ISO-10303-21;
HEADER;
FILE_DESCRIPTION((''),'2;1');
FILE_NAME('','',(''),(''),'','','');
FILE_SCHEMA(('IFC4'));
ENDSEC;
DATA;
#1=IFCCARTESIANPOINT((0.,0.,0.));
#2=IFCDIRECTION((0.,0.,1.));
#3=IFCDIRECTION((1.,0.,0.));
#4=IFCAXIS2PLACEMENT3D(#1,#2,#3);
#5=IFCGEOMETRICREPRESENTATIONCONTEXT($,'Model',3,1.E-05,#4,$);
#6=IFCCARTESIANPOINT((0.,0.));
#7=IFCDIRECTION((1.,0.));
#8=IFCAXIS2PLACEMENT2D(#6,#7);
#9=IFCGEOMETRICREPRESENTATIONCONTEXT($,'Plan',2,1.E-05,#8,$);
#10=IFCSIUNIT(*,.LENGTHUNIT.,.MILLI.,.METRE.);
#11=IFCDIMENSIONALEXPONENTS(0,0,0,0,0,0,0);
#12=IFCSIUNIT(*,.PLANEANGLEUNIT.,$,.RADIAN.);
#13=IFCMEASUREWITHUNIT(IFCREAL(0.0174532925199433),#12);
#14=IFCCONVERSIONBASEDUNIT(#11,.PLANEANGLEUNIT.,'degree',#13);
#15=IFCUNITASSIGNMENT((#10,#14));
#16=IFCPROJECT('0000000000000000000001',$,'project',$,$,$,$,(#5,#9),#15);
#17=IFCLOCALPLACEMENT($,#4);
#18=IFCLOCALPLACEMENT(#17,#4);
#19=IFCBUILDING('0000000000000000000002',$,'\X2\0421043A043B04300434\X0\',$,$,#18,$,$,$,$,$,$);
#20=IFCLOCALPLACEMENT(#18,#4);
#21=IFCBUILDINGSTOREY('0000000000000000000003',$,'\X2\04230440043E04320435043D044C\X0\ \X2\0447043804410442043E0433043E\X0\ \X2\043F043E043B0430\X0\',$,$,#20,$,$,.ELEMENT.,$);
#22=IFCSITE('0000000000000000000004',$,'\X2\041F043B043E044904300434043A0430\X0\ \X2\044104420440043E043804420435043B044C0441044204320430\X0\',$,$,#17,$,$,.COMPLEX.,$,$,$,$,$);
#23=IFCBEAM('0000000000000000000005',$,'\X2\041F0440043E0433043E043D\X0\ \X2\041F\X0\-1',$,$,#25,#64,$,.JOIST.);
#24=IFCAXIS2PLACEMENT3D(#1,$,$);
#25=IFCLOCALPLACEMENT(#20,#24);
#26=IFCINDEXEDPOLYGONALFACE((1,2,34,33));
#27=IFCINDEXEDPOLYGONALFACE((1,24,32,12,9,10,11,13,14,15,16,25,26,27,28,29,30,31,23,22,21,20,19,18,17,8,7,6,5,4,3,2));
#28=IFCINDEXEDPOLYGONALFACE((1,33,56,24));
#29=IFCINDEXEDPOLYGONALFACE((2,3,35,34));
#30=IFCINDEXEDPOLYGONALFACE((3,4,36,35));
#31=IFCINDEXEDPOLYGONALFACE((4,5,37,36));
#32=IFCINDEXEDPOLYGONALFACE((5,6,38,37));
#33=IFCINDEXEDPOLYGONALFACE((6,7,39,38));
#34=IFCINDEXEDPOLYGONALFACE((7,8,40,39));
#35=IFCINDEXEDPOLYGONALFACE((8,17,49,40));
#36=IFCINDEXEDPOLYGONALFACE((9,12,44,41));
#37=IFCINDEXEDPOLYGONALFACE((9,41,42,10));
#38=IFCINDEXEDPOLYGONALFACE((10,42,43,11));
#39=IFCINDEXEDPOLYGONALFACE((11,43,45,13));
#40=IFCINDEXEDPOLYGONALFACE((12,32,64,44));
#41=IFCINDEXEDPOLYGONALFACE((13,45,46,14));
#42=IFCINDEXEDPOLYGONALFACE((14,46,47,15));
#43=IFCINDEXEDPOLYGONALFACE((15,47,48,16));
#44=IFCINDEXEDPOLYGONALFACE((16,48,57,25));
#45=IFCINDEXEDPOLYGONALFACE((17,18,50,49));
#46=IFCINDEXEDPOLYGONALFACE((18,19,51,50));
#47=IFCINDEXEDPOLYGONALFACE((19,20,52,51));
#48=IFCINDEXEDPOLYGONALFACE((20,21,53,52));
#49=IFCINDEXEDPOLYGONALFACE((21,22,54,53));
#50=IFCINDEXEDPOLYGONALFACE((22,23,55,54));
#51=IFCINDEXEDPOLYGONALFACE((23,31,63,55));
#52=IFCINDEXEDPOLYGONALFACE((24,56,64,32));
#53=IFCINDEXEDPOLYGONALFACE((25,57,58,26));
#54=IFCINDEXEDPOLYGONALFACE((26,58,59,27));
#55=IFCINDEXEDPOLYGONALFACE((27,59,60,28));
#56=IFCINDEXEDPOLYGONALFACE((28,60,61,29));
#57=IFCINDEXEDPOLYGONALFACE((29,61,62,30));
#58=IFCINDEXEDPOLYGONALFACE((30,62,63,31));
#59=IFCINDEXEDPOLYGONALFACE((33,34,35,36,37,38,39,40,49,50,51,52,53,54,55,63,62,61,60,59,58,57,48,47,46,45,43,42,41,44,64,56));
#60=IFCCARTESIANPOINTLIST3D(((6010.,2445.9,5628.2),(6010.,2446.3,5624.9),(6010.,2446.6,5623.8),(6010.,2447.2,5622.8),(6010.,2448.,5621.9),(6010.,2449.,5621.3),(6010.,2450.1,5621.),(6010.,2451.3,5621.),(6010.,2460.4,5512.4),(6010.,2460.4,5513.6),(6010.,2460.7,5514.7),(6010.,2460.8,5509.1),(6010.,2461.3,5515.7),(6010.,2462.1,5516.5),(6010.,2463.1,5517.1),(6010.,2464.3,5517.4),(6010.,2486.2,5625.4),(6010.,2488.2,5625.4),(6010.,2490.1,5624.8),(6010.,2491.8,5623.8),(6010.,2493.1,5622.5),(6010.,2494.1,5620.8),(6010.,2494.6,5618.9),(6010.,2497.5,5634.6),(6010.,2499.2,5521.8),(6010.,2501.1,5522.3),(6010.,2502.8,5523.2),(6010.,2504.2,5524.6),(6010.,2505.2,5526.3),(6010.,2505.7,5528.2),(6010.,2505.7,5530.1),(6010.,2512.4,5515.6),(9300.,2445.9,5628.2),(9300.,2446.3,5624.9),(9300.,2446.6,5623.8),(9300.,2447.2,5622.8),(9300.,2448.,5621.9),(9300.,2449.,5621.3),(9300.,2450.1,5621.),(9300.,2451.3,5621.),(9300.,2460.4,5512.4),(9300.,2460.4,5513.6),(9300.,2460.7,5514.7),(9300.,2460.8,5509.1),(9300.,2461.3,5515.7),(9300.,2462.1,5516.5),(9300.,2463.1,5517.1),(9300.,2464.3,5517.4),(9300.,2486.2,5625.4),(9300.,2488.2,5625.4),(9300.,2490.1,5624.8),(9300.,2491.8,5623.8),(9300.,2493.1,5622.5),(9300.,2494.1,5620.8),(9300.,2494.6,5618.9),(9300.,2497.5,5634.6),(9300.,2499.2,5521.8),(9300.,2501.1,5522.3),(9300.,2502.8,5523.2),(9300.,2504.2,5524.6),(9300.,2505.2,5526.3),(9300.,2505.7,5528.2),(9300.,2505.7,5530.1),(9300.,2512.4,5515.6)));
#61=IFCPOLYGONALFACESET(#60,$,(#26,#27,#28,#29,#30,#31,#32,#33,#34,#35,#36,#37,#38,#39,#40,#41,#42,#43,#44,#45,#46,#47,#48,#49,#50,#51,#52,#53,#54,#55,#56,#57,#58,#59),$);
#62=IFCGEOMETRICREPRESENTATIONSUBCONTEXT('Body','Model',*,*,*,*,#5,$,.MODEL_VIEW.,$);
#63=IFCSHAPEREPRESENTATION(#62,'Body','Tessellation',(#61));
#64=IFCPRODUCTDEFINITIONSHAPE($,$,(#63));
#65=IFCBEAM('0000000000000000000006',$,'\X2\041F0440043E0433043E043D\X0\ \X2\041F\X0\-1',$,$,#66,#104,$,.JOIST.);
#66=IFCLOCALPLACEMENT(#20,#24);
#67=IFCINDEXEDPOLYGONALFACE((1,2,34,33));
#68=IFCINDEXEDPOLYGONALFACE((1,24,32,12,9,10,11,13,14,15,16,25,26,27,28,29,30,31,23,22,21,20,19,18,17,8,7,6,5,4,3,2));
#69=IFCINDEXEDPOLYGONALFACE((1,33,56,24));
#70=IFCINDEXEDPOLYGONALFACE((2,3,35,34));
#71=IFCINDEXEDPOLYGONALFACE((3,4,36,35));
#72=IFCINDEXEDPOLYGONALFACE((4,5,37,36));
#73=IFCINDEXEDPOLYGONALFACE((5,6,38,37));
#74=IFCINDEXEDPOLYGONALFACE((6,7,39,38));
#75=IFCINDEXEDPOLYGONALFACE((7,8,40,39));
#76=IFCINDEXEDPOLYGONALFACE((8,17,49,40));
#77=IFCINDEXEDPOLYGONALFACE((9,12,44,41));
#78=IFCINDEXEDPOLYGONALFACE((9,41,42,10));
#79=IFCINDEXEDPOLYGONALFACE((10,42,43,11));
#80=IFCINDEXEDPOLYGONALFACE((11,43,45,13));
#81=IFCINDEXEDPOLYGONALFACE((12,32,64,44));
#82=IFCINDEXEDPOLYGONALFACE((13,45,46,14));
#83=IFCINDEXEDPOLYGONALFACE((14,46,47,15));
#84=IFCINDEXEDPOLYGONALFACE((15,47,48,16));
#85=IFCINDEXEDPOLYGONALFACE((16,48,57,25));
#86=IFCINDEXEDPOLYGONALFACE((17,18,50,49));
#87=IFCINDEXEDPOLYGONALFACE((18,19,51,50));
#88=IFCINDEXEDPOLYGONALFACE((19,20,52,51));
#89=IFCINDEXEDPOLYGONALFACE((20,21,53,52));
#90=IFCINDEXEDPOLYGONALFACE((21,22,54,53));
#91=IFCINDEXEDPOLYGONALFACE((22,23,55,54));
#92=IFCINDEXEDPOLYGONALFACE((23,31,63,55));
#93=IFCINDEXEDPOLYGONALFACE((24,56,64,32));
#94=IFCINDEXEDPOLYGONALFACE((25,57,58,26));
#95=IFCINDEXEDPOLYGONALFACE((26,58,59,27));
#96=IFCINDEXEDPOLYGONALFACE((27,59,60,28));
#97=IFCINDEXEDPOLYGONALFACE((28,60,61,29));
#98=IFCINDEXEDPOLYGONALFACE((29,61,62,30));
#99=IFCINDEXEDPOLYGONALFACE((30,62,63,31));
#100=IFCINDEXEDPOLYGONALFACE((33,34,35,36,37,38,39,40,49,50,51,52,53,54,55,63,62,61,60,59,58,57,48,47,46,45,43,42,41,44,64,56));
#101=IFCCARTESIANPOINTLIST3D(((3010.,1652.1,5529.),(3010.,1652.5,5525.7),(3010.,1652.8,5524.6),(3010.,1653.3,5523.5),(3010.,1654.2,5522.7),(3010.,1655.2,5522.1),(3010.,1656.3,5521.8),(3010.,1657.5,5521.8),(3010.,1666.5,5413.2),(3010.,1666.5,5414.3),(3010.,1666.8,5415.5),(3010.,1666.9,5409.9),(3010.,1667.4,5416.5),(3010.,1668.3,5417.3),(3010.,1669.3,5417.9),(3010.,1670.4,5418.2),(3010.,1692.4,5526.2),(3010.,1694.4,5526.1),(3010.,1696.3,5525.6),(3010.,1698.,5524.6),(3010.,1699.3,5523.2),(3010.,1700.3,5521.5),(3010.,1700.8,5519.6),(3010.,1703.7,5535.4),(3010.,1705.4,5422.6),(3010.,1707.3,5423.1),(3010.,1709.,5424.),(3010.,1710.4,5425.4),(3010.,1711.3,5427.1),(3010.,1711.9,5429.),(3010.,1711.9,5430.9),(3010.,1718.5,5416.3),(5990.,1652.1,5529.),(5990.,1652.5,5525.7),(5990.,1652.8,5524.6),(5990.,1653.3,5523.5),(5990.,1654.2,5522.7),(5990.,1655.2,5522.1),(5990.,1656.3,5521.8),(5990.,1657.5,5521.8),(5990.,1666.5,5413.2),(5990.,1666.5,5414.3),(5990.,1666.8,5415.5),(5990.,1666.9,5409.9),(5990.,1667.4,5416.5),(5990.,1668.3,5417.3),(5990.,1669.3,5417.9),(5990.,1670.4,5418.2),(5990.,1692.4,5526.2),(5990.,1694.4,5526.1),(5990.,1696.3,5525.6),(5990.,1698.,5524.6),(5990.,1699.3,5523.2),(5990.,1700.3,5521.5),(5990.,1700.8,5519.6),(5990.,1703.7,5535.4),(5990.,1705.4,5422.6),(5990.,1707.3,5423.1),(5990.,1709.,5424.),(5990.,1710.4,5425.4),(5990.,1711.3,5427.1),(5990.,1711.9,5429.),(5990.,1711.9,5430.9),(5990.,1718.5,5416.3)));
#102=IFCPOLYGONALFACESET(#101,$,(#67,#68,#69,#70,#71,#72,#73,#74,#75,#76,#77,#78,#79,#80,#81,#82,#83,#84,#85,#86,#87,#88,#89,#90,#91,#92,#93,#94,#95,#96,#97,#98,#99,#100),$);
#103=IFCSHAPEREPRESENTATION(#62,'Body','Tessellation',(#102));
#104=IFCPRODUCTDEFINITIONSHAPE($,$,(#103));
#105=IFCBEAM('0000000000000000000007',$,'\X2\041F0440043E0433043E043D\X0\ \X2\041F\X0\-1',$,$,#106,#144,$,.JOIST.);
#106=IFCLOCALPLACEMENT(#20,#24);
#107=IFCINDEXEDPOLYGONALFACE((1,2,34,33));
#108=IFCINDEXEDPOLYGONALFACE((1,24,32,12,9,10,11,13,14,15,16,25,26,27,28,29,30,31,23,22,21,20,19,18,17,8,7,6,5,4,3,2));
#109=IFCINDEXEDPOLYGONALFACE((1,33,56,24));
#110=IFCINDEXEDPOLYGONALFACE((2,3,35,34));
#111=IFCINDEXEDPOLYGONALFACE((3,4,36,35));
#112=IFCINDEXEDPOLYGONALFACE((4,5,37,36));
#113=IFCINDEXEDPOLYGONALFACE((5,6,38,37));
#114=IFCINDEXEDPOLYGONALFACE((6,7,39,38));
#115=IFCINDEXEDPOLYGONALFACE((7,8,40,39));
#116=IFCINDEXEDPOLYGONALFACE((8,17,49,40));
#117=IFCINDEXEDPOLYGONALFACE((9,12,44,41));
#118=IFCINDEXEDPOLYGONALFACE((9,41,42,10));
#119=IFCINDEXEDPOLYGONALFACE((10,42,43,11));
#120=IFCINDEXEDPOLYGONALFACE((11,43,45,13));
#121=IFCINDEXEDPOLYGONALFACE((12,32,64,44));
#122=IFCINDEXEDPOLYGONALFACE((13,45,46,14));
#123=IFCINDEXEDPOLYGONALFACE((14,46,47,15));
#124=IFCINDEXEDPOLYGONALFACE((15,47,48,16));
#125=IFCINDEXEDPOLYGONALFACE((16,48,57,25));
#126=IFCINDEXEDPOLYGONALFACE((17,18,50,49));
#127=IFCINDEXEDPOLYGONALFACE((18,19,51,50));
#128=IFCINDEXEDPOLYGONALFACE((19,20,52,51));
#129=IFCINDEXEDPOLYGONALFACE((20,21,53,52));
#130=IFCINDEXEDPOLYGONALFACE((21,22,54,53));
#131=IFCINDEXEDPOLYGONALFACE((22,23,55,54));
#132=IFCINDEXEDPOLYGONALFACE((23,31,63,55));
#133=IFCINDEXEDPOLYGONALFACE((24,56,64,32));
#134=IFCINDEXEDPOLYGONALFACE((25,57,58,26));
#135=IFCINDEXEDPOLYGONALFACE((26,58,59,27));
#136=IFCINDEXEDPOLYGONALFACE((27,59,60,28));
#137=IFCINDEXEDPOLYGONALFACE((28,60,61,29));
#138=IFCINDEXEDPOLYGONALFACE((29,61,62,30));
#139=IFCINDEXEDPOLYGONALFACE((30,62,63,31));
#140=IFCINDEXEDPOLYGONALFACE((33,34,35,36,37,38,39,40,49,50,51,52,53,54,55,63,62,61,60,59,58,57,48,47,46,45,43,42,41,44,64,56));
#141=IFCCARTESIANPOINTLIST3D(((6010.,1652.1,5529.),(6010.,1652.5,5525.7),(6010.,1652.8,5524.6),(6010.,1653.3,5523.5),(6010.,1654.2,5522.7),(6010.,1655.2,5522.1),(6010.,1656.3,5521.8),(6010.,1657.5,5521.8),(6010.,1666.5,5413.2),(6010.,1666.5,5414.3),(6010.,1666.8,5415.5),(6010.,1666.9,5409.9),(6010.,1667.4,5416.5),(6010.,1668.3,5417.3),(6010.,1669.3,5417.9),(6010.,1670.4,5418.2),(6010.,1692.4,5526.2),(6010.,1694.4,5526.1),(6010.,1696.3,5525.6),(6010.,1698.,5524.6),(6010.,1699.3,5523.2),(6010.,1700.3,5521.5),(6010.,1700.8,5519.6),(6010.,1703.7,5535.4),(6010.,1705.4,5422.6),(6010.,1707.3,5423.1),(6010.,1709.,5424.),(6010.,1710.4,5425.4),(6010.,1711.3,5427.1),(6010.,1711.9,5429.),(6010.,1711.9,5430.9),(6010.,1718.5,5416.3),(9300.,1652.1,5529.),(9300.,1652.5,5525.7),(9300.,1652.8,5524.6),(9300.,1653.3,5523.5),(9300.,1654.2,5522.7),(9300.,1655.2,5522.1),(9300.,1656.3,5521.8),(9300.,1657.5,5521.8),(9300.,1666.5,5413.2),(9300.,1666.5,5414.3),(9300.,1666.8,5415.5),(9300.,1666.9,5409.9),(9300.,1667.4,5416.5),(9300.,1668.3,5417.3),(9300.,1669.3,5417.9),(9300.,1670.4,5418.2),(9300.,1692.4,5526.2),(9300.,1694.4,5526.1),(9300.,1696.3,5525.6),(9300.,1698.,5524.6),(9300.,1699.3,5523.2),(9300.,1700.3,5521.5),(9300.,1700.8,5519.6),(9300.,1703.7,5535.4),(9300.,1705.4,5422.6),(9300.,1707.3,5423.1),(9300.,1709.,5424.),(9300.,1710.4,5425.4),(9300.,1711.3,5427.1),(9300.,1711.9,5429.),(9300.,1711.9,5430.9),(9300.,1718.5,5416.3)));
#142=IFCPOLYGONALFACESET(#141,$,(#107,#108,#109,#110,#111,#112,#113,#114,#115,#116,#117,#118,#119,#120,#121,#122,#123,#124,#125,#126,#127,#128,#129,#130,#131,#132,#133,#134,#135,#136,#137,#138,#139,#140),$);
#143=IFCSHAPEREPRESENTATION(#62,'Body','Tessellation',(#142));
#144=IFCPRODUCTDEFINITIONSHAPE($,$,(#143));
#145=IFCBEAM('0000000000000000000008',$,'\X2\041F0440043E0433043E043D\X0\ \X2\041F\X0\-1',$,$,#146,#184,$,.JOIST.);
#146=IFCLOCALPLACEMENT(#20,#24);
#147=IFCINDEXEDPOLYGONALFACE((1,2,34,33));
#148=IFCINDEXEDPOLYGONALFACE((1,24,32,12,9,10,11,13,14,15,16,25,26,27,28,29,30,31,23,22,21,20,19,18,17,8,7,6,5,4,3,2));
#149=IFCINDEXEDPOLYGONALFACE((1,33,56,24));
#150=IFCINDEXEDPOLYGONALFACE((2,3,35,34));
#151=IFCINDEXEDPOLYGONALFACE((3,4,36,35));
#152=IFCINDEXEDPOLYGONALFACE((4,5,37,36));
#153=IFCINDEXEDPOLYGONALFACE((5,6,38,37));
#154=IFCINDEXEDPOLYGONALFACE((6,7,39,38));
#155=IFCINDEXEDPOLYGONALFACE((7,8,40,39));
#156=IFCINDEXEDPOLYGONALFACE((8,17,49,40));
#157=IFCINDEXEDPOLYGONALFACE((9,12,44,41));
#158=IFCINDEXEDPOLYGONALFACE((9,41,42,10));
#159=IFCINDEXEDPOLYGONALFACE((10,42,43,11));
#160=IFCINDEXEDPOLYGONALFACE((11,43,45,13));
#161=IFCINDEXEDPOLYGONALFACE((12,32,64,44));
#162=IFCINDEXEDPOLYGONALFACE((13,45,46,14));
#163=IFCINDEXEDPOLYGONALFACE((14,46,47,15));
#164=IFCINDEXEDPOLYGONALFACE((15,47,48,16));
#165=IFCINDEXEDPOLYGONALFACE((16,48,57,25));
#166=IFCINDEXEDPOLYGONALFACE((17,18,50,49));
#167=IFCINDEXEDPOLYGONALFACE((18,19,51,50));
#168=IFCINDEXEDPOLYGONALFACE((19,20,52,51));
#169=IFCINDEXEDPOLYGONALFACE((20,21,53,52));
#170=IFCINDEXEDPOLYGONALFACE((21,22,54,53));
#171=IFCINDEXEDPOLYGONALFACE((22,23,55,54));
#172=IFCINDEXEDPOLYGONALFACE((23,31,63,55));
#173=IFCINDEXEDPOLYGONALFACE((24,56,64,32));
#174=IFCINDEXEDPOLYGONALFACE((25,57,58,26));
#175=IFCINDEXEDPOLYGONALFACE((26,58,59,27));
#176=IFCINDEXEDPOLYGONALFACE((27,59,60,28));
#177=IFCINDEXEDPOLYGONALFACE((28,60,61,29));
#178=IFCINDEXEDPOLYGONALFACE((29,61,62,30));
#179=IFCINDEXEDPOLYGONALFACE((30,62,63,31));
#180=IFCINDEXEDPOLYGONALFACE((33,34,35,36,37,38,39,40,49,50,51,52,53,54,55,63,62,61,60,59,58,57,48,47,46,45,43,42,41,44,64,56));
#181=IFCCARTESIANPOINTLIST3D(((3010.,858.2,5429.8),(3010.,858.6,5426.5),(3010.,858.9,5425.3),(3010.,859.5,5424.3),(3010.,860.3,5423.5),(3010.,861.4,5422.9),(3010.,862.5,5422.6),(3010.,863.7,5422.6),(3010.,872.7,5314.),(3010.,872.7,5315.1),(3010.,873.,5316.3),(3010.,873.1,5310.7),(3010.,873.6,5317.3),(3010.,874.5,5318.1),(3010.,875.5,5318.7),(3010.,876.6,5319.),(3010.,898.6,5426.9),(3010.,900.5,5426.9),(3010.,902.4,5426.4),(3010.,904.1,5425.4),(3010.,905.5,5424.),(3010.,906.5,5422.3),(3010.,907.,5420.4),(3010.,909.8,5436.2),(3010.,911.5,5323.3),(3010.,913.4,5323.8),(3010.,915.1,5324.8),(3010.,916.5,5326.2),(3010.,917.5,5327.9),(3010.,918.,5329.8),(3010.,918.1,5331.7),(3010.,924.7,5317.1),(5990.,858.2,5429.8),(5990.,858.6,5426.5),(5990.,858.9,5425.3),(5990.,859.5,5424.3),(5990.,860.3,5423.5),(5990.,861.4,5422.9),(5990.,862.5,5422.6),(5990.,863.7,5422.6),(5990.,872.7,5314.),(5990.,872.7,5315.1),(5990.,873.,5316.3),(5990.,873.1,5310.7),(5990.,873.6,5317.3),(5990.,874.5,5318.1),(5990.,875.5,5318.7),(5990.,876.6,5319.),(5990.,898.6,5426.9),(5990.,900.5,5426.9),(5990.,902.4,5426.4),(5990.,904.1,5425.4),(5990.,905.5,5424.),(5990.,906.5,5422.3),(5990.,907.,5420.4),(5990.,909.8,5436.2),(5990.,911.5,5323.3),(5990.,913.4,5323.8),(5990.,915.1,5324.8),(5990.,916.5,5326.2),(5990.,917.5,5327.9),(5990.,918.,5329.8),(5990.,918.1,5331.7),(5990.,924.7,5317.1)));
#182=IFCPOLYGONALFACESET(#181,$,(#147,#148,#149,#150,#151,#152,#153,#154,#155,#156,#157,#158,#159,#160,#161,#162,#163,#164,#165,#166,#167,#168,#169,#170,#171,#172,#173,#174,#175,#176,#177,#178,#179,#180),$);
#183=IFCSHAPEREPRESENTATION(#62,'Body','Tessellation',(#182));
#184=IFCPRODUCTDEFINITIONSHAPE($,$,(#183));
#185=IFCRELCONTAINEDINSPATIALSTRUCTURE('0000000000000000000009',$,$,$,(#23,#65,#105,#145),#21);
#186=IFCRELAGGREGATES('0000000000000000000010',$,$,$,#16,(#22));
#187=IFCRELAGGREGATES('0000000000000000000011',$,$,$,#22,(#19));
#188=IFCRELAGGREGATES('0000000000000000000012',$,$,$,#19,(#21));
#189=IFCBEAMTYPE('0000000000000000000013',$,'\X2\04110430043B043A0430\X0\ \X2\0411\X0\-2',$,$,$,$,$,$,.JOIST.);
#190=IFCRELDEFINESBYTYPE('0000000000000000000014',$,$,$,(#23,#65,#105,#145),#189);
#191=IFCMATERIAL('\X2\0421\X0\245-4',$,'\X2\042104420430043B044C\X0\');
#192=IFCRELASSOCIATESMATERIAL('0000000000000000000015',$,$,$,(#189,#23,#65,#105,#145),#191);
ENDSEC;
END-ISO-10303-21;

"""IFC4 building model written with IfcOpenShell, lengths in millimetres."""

from ifc_helpers import new_model, entity, si_unit, converted_unit, frame, origin_with_axes, origin_2d_with_axis, place, context, subcontext, project, spatial, u_section, extrude, material, material_profile, profile_set, profile_usage, type_object, element, save


model = new_model("IFC4")

# Units and contexts
model_context = context("Model", 3, precision=1e-05, world=origin_with_axes())
plan_context = context("Plan", 2, precision=1e-05, world=origin_2d_with_axis())
body_context = subcontext(model_context, "Body", "Model", "MODEL_VIEW")
ifc_project = project(units=[si_unit("LENGTHUNIT", "METRE", prefix="MILLI"), converted_unit("PLANEANGLEUNIT", "degree", entity("IfcReal", 0.0174532925199433), si_unit("PLANEANGLEUNIT", "RADIAN"), dimensions=[0, 0, 0, 0, 0, 0, 0])], contexts=[model_context, plan_context])

# Site, building, storey
site_placement = place(None, origin_with_axes())
site = spatial("IfcSite", under=ifc_project, at=site_placement, Name="Площадка строительства", CompositionType="COMPLEX")
building_placement = place(site_placement, origin_with_axes())
building = spatial("IfcBuilding", under=site, at=building_placement, Name="Склад")
storey_placement = place(building_placement, origin_with_axes())
storey = spatial("IfcBuildingStorey", under=building, at=storey_placement, Name="Уровень чистого пола", CompositionType="ELEMENT")

# Beams
ifc_material_1 = material(Name="С245-4", Category="Сталь")
ifc_material_profile_1 = material_profile(ifc_material_1, u_section(Depth=120.0, FlangeWidth=52.0, WebThickness=4.8, FlangeThickness=7.8, FilletRadius=7.5, EdgeRadius=4.5, FlangeSlope=0.0))
ifc_profile_set_1 = profile_set([ifc_material_profile_1], Name="U12P_S245-4")
beam_type_1 = type_object("IfcBeamType", Name="Балка Б-2", PredefinedType="JOIST", material=ifc_profile_set_1)
ifc_profile_usage_1 = profile_usage(ifc_profile_set_1, cardinal=3)
beam_1_placement = place(storey_placement, frame((9300.0, 2512.4, 5515.6), z_axis=(-1.0, 0.0, 0.0), x_axis=(0.0, -0.99228, -0.12402)))
element("IfcBeam", 1, at=beam_1_placement, inside=storey, type_object=beam_type_1, material=ifc_profile_usage_1, Name="Прогон П-1", PredefinedType="JOIST", context=body_context, shape_type="SweptSolid", body=[
    extrude(u_section(Depth=120.0, FlangeWidth=52.0, WebThickness=4.8, FlangeThickness=7.8, FilletRadius=7.5, EdgeRadius=4.5, FlangeSlope=0.0), frame((26.0, 60.0, 0.0), z_axis=(0.0, 0.0, 1.0), x_axis=(1.0, 0.0, 0.0)), (0.0, 0.0, 1.0), 3290.0),
])
ifc_profile_usage_2 = profile_usage(ifc_profile_set_1, cardinal=3)
beam_2_placement = place(storey_placement, frame((5990.0, 1718.5, 5416.3), z_axis=(-1.0, 0.0, 0.0), x_axis=(0.0, -0.99228, -0.12402)))
element("IfcBeam", 2, at=beam_2_placement, inside=storey, type_object=beam_type_1, material=ifc_profile_usage_2, Name="Прогон П-1", PredefinedType="JOIST", context=body_context, shape_type="SweptSolid", body=[
    extrude(u_section(Depth=120.0, FlangeWidth=52.0, WebThickness=4.8, FlangeThickness=7.8, FilletRadius=7.5, EdgeRadius=4.5, FlangeSlope=0.0), frame((26.0, 60.0, 0.0), z_axis=(0.0, 0.0, 1.0), x_axis=(1.0, 0.0, 0.0)), (0.0, 0.0, 1.0), 2980.0),
])
ifc_profile_usage_3 = profile_usage(ifc_profile_set_1, cardinal=3)
beam_3_placement = place(storey_placement, frame((9300.0, 1718.5, 5416.3), z_axis=(-1.0, 0.0, 0.0), x_axis=(0.0, -0.99228, -0.12402)))
element("IfcBeam", 3, at=beam_3_placement, inside=storey, type_object=beam_type_1, material=ifc_profile_usage_3, Name="Прогон П-1", PredefinedType="JOIST", context=body_context, shape_type="SweptSolid", body=[
    extrude(u_section(Depth=120.0, FlangeWidth=52.0, WebThickness=4.8, FlangeThickness=7.8, FilletRadius=7.5, EdgeRadius=4.5, FlangeSlope=0.0), frame((26.0, 60.0, 0.0), z_axis=(0.0, 0.0, 1.0), x_axis=(1.0, 0.0, 0.0)), (0.0, 0.0, 1.0), 3290.0),
])
ifc_profile_usage_4 = profile_usage(ifc_profile_set_1, cardinal=3)
beam_4_placement = place(storey_placement, frame((5990.0, 924.7, 5317.1), z_axis=(-1.0, 0.0, 0.0), x_axis=(0.0, -0.99228, -0.12402)))
element("IfcBeam", 4, at=beam_4_placement, inside=storey, type_object=beam_type_1, material=ifc_profile_usage_4, Name="Прогон П-1", PredefinedType="JOIST", context=body_context, shape_type="SweptSolid", body=[
    extrude(u_section(Depth=120.0, FlangeWidth=52.0, WebThickness=4.8, FlangeThickness=7.8, FilletRadius=7.5, EdgeRadius=4.5, FlangeSlope=0.0), frame((26.0, 60.0, 0.0), z_axis=(0.0, 0.0, 1.0), x_axis=(1.0, 0.0, 0.0)), (0.0, 0.0, 1.0), 2980.0),
])

save(model, "model.ifc")
